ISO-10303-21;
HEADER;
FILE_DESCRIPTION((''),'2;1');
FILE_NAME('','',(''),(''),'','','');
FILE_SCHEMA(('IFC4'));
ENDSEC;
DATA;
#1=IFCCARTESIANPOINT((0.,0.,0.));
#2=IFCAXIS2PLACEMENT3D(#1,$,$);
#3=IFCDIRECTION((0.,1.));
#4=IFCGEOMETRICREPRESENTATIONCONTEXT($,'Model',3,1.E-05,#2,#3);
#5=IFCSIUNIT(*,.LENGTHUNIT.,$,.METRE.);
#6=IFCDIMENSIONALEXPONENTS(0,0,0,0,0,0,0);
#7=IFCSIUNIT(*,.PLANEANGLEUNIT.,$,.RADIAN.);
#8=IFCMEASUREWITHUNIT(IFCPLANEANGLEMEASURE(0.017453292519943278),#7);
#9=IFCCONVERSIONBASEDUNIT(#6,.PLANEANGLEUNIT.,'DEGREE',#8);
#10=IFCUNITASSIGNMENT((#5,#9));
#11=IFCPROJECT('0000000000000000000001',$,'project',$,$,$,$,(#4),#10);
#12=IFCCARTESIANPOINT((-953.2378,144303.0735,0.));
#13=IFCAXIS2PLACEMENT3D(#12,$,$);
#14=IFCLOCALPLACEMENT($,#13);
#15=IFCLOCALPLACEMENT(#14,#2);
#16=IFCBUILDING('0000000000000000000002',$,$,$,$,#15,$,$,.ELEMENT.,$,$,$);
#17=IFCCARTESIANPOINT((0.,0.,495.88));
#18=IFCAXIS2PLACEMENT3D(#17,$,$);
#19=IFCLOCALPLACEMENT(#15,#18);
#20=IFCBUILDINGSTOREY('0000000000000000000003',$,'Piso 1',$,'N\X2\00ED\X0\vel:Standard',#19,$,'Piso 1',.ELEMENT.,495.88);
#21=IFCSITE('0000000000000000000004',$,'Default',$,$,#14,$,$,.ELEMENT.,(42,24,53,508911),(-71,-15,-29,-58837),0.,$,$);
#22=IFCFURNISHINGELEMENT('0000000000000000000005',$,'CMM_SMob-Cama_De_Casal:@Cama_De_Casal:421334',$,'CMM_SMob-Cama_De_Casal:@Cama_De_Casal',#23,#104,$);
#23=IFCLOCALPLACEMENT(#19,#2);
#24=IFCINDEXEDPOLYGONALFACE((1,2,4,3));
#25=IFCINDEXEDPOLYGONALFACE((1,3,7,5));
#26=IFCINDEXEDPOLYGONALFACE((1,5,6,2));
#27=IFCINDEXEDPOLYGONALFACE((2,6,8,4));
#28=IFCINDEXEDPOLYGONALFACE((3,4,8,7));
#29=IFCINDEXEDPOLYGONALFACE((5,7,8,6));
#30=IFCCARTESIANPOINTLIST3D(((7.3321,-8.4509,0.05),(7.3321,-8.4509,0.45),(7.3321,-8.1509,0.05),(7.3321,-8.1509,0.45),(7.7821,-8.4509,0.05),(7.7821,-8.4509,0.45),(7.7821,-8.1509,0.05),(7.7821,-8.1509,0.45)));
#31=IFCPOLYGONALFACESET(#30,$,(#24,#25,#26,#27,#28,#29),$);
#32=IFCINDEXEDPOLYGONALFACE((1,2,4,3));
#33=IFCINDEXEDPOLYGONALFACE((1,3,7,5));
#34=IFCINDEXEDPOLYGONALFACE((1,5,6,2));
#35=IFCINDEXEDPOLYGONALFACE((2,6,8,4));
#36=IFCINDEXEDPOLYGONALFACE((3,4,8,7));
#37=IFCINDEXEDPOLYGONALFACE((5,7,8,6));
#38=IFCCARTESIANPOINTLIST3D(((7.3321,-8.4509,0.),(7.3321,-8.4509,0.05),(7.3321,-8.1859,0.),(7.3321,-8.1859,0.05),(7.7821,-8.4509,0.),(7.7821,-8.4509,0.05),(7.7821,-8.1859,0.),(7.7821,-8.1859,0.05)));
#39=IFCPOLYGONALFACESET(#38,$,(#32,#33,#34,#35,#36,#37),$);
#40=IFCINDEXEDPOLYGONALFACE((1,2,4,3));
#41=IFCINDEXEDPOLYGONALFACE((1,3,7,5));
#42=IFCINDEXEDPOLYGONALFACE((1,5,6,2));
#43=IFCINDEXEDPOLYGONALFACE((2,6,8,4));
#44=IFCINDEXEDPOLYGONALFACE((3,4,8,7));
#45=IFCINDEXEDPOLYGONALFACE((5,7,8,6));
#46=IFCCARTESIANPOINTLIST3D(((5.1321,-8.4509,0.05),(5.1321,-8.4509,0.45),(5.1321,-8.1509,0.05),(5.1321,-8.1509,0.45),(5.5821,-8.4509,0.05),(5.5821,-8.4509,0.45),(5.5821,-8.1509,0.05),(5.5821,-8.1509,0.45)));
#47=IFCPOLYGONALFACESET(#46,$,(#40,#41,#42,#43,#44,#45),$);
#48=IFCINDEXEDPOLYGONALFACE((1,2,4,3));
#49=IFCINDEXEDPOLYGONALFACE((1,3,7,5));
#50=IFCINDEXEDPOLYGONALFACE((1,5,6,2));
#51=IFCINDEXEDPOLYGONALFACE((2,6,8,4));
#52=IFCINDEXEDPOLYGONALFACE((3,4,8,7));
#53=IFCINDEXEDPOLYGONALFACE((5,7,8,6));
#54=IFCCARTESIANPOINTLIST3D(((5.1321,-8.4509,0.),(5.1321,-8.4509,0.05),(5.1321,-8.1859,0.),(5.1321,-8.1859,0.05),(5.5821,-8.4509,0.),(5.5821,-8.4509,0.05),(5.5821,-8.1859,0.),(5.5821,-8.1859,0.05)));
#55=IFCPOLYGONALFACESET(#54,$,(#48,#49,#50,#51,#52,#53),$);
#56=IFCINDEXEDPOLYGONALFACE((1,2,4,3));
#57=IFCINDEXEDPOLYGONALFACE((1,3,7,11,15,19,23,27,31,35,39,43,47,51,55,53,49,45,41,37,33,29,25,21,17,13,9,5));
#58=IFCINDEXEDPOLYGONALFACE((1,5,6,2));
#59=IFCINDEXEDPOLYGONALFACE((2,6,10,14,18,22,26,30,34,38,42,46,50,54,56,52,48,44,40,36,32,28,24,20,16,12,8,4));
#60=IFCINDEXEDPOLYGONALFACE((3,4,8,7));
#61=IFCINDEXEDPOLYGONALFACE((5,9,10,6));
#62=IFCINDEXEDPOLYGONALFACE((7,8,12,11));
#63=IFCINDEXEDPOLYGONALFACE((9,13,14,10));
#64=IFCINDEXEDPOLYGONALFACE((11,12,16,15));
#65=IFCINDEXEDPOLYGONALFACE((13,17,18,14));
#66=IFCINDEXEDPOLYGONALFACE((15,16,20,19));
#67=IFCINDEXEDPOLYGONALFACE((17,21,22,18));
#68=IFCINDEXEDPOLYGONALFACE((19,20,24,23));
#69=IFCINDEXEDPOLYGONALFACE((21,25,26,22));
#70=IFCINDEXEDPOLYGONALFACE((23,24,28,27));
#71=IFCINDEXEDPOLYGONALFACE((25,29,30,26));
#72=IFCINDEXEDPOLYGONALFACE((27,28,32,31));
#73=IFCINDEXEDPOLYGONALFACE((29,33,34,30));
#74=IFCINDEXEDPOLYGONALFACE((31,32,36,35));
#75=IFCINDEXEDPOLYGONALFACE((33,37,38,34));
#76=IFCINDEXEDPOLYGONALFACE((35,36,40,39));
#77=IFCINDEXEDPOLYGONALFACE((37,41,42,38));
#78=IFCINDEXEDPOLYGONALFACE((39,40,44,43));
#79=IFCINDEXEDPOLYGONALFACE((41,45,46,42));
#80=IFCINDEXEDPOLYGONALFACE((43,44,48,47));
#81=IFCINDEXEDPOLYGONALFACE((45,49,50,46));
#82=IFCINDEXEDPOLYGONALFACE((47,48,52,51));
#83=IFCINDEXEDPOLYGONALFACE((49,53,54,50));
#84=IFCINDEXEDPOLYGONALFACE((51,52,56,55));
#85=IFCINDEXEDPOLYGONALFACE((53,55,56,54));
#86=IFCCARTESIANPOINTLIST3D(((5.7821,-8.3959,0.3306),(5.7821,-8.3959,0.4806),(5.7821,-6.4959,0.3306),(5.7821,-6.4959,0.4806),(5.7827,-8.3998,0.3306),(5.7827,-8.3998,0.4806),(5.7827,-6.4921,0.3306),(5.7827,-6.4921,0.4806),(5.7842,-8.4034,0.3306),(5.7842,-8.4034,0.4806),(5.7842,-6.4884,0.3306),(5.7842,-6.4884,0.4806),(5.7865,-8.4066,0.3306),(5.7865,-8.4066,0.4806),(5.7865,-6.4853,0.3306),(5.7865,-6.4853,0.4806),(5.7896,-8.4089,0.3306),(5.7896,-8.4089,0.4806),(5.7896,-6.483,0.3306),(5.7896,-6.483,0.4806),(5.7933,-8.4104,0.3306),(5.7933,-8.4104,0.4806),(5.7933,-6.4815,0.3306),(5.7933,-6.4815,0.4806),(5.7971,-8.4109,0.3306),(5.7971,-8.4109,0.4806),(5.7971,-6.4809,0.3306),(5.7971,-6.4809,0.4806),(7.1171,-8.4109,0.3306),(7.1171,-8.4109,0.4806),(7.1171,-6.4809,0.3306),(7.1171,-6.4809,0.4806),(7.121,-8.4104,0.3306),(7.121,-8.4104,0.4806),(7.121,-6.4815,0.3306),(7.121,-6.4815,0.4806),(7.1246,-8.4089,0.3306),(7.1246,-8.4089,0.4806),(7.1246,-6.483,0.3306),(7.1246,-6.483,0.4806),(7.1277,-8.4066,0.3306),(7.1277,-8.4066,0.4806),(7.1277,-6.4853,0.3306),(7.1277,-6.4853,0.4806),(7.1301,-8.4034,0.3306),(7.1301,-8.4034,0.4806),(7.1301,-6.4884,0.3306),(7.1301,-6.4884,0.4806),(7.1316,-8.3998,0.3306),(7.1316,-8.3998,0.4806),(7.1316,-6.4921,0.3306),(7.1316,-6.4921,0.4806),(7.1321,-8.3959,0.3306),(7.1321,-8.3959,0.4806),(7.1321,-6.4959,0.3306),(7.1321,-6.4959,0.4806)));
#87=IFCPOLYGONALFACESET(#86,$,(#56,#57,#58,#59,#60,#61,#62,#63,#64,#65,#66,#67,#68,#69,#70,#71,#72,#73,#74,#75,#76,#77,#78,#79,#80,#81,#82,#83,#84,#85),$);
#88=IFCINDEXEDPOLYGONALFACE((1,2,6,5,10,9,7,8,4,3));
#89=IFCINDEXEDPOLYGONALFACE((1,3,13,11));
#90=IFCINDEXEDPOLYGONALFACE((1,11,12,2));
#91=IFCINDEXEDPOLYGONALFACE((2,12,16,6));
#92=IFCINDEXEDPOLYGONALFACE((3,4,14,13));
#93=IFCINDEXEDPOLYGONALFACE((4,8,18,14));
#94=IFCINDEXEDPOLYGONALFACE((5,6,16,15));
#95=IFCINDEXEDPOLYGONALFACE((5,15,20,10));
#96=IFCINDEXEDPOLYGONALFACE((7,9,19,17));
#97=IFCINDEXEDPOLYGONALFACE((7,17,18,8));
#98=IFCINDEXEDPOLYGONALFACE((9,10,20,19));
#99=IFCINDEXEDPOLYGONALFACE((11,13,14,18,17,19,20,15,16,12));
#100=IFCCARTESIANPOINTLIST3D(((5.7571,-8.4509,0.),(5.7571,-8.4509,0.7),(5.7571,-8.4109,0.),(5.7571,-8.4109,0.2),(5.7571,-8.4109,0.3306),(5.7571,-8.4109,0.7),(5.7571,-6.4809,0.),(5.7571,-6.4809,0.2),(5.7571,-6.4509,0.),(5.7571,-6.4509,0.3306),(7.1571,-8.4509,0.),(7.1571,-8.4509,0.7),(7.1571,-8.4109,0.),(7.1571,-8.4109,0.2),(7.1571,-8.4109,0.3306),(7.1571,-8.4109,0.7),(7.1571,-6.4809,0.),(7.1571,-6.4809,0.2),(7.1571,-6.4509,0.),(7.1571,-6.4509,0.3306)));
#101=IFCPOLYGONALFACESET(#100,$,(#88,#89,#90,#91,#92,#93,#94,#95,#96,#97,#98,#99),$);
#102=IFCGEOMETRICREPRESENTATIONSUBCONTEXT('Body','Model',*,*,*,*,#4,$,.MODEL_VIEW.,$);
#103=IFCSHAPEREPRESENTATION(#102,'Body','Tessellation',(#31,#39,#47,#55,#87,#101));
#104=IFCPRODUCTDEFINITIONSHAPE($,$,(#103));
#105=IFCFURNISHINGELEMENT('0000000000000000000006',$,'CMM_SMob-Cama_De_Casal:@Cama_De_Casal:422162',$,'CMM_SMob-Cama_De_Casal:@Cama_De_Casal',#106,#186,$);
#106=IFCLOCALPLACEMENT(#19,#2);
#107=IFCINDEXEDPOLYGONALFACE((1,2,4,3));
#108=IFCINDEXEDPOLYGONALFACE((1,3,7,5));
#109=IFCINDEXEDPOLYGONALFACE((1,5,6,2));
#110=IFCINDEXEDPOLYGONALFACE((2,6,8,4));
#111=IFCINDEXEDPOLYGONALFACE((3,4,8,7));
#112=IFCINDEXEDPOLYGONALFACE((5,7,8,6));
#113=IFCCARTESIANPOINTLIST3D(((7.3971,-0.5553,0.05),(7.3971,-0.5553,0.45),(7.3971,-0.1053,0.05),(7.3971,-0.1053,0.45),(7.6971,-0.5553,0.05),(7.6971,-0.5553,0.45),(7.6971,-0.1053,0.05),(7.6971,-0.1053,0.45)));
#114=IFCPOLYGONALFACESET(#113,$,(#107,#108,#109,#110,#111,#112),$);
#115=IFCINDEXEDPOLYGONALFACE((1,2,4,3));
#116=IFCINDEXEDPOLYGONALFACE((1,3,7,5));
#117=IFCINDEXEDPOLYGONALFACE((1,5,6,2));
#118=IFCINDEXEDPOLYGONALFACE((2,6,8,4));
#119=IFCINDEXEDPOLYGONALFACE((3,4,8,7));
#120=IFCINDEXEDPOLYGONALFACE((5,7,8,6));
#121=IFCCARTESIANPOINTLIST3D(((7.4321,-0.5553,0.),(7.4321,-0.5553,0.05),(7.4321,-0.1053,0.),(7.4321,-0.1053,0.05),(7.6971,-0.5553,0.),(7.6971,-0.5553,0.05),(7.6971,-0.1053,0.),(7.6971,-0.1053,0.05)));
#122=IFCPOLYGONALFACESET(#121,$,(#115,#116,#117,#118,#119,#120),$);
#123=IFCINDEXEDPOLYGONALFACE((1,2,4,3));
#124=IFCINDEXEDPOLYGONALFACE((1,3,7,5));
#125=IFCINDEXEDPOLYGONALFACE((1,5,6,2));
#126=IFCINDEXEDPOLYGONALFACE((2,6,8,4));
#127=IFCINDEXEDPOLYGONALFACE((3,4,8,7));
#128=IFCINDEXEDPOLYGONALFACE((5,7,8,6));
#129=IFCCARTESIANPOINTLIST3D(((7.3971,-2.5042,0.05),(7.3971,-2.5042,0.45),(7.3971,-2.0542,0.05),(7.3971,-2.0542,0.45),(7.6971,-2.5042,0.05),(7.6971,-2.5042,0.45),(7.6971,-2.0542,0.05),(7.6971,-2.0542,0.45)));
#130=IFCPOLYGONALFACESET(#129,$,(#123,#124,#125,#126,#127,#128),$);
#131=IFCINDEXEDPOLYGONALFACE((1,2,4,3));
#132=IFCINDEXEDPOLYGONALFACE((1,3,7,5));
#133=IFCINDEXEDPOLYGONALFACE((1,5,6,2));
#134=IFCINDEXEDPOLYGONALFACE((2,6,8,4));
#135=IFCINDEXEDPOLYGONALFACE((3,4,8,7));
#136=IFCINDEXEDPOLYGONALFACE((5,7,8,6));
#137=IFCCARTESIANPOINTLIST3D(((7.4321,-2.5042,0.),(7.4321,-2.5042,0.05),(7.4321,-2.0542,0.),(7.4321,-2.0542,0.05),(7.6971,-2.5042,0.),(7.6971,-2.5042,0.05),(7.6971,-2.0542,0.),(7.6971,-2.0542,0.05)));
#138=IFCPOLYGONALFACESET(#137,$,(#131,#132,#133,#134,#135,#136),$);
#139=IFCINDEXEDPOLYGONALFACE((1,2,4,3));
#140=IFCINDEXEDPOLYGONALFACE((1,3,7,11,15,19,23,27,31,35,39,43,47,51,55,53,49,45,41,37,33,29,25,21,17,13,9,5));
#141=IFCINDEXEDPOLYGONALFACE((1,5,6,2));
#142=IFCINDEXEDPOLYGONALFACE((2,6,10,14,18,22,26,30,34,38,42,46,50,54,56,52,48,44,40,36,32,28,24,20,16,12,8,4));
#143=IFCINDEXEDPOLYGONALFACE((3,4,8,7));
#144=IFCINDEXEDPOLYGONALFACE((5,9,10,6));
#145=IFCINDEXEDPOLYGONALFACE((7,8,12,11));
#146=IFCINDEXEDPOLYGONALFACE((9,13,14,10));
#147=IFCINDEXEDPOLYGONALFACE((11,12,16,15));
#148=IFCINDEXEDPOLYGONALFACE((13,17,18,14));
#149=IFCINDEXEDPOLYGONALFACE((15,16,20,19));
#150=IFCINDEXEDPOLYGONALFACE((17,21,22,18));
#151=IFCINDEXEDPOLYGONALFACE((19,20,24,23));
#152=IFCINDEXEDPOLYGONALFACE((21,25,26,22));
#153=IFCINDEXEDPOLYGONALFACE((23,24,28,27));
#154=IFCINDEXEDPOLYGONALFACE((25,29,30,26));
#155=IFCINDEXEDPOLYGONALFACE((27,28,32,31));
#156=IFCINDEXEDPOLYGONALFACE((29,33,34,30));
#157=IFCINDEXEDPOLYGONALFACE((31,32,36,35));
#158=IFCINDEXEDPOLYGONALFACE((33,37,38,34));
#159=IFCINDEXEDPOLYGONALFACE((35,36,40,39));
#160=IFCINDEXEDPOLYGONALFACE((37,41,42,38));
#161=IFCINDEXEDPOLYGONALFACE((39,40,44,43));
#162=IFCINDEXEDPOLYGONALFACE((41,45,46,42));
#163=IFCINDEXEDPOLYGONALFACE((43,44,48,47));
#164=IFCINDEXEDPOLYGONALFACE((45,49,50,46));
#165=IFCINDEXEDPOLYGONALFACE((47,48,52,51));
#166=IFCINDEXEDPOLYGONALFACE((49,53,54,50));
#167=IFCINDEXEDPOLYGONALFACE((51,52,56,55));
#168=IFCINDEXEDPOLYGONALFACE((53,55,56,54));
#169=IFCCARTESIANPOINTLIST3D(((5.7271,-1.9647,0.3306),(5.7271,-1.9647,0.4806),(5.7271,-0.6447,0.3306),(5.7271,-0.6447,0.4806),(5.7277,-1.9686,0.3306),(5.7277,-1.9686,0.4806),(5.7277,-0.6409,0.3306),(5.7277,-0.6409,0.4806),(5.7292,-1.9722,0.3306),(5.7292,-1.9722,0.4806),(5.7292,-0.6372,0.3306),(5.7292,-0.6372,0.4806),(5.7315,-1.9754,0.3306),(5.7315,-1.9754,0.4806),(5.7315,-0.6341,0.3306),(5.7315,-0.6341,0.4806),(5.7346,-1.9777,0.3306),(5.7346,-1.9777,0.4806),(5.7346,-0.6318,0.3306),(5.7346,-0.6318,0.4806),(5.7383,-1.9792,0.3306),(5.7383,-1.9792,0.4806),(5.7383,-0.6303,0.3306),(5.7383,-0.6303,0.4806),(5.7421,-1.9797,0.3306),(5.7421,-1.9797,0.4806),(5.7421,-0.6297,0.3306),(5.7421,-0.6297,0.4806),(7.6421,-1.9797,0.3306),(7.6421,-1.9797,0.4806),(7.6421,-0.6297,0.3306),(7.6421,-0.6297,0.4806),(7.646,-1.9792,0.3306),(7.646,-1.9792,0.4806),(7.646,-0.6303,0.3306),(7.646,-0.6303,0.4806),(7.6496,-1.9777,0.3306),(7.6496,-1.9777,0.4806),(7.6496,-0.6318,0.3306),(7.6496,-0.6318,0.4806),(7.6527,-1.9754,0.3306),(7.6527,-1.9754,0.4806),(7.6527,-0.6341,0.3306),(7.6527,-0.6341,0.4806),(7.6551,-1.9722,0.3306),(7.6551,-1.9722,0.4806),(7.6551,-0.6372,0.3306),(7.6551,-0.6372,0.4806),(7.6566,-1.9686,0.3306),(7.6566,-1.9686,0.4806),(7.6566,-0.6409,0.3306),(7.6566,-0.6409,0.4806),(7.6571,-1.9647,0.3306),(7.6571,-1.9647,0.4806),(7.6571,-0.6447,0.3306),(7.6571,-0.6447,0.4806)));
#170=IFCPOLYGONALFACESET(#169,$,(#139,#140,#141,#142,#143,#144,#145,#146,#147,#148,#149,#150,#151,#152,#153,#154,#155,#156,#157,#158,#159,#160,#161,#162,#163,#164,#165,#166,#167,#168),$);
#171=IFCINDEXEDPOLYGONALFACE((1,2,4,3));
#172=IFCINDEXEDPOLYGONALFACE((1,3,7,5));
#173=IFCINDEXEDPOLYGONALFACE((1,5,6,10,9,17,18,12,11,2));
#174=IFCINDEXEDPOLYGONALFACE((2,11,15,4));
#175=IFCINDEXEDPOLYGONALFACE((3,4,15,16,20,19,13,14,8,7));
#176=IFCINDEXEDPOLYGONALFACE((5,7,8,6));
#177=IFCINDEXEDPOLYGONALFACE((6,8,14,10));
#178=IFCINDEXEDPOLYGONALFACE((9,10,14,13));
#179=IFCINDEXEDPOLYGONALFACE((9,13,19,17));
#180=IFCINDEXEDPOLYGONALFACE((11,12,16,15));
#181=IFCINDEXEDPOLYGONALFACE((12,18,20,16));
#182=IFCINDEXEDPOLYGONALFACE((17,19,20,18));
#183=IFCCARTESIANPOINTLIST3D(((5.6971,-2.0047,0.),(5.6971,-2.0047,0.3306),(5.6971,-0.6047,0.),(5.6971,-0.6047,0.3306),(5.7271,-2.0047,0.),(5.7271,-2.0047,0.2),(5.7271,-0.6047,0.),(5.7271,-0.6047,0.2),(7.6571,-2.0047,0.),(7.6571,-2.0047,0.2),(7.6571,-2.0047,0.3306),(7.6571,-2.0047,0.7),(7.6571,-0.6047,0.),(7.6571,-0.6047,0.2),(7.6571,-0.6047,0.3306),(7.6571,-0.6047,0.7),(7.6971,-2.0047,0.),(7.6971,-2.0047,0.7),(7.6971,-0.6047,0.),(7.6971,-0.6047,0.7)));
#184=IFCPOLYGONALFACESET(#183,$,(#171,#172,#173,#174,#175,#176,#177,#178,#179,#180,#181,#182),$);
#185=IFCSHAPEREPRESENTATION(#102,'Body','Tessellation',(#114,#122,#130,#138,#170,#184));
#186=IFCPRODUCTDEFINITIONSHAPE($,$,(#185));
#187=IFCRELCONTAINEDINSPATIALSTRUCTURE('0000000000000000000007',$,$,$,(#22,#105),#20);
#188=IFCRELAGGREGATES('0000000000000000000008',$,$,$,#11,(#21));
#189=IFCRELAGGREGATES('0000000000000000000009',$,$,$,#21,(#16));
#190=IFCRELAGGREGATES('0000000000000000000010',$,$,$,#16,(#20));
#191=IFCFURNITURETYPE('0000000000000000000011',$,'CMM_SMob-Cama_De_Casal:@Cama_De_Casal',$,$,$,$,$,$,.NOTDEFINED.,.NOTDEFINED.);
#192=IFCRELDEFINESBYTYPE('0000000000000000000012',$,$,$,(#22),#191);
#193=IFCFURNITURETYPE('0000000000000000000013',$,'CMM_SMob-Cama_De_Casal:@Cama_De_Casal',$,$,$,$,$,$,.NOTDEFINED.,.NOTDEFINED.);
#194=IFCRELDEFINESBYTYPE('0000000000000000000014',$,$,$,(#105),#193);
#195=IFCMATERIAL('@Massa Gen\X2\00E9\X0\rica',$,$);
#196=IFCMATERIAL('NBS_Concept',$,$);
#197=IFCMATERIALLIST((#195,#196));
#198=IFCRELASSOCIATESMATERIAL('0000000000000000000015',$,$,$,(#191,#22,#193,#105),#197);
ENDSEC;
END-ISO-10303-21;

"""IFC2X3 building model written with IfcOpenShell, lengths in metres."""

from ifc_helpers import new_model, entity, si_unit, converted_unit, direction, frame, frame_2d, origin, origin_2d_with_axis, place, context, subcontext, project, spatial, polyline, circle_curve, parameter, trimmed, segment, composite_curve, rectangle, outline, extrude, source, transform, mapped, material, material_list, type_object, type_shapes, element, save


model = new_model("IFC2X3")

# Units and contexts
model_context = context("Model", 3, precision=1e-05, world=origin(), true_north=direction((0.0, 1.0)))
body_context = subcontext(model_context, "Body", "Model", "MODEL_VIEW")
ifc_project = project(units=[si_unit("LENGTHUNIT", "METRE"), converted_unit("PLANEANGLEUNIT", "DEGREE", entity("IfcPlaneAngleMeasure", 0.017453292519943278), si_unit("PLANEANGLEUNIT", "RADIAN"), dimensions=[0, 0, 0, 0, 0, 0, 0])], contexts=[model_context])

# Site, building, storey
site_placement = place(None, frame((-953.2378, 144303.0735, 0.0)))
site = spatial("IfcSite", under=ifc_project, at=site_placement, Name="Default", CompositionType="ELEMENT", RefLatitude=(42, 24, 53, 508911), RefLongitude=(-71, -15, -29, -58837), RefElevation=0.0)
building_placement = place(site_placement, origin())
building = spatial("IfcBuilding", under=site, at=building_placement, CompositionType="ELEMENT")
storey_placement = place(building_placement, frame((0.0, 0.0, 495.88)))
storey = spatial("IfcBuildingStorey", under=building, at=storey_placement, Name="Piso 1", ObjectType="Nível:Standard", LongName="Piso 1", CompositionType="ELEMENT", Elevation=495.88)

# Furnishing elements
ifc_material_1 = material(Name="@Massa Genérica")
ifc_material_2 = material(Name="NBS_Concept")
ifc_material_list = material_list([ifc_material_1, ifc_material_2])
furniture_type_1 = type_object("IfcFurnitureType", Name="CMM_SMob-Cama_De_Casal:@Cama_De_Casal", AssemblyPlace="NOTDEFINED", material=ifc_material_list)
shared_shape_1 = source(origin(), body_context, "Body", "SweptSolid", [
    extrude(rectangle(XDim=0.3, YDim=0.45, at=origin_2d_with_axis()), frame((-1.1, -0.15, 0.05), z_axis=(0.0, 0.0, 1.0), x_axis=(0.0, 1.0, 0.0)), (0.0, 0.0, 1.0), 0.4),
    extrude(rectangle(XDim=0.265, YDim=0.45, at=frame_2d((0.0, 0.0), x_axis=(1.0, 0.0))), frame((-1.1, -0.1325, 0.0), z_axis=(0.0, 0.0, 1.0), x_axis=(0.0, -1.0, 0.0)), (0.0, 0.0, 1.0), 0.05),
    extrude(rectangle(XDim=0.45, YDim=0.3, at=frame_2d((0.0, 0.0), x_axis=(1.0, 0.0))), frame((1.1, -0.15, 0.05)), (0.0, 0.0, 1.0), 0.4),
    extrude(rectangle(XDim=0.45, YDim=0.265, at=origin_2d_with_axis()), frame((1.1, -0.1325, 0.0), z_axis=(0.0, 0.0, 1.0), x_axis=(-1.0, 0.0, 0.0)), (0.0, 0.0, 1.0), 0.05),
    extrude(outline(composite_curve([segment(polyline([(-0.66, -0.965), (0.66, -0.965)]), True, "CONTINUOUS"), segment(trimmed(circle_curve(frame_2d((0.66, -0.95), x_axis=(-1.0, 0.0)), 0.015), [parameter(90.0)], [parameter(180.0)], True, "PARAMETER"), True, "CONTINUOUS"), segment(polyline([(0.675, -0.95), (0.675, 0.95)]), True, "CONTINUOUS"), segment(trimmed(circle_curve(frame_2d((0.66, 0.95), x_axis=(-1.0, 0.0)), 0.015), [parameter(180.0)], [parameter(270.0)], True, "PARAMETER"), True, "CONTINUOUS"), segment(polyline([(0.66, 0.965), (-0.66, 0.965)]), True, "CONTINUOUS"), segment(trimmed(circle_curve(frame_2d((-0.66, 0.95), x_axis=(-1.0, 0.0)), 0.015), [parameter(270.0)], [parameter(0.0)], True, "PARAMETER"), True, "CONTINUOUS"), segment(polyline([(-0.675, 0.95), (-0.675, -0.95)]), True, "CONTINUOUS"), segment(trimmed(circle_curve(frame_2d((-0.66, -0.95), x_axis=(-1.0, 0.0)), 0.015), [parameter(0.0)], [parameter(90.0)], True, "PARAMETER"), True, "CONTINUOUS")], self_intersect=False)), frame((0.0, -1.005, 0.3306), z_axis=(0.0, 0.0, 1.0), x_axis=(-1.0, 0.0, 0.0)), (0.0, 0.0, 1.0), 0.15),
    extrude(outline(polyline([(-0.2461, -1.16), (-0.2461, -1.19), (0.0845, -1.19), (0.0845, 0.77), (0.4539, 0.77), (0.4539, 0.81), (-0.2461, 0.81), (-0.2461, 0.77), (-0.0461, 0.77), (-0.0461, -1.16), (-0.2461, -1.16)])), frame((-0.7, -0.81, 0.2461), z_axis=(-1.0, 0.0, 0.0), x_axis=(0.0, 0.0, 1.0)), (0.0, 0.0, -1.0), 1.4),
])
type_shapes(furniture_type_1, [shared_shape_1])
furnishing_1_placement = place(storey_placement, frame((6.4571, -8.4509, 0.0), z_axis=(0.0, 0.0, 1.0), x_axis=(-1.0, 0.0, 0.0)))
element("IfcFurnishingElement", 1, at=furnishing_1_placement, inside=storey, type_object=furniture_type_1, material=ifc_material_list, Name="CMM_SMob-Cama_De_Casal:@Cama_De_Casal:421334", ObjectType="CMM_SMob-Cama_De_Casal:@Cama_De_Casal", context=body_context, shape_type="MappedRepresentation", body=[
    mapped(shared_shape_1, transform((0.0, 0.0, 0.0), scale=1.0)),
])
furniture_type_2 = type_object("IfcFurnitureType", Name="CMM_SMob-Cama_De_Casal:@Cama_De_Casal", AssemblyPlace="NOTDEFINED", material=ifc_material_list)
shared_shape_2 = source(origin(), body_context, "Body", "SweptSolid", [
    extrude(rectangle(XDim=0.3, YDim=0.45, at=frame_2d((0.0, 0.0), x_axis=(1.0, 0.0))), frame((-0.9745, -0.15, 0.05), z_axis=(0.0, 0.0, 1.0), x_axis=(0.0, 1.0, 0.0)), (0.0, 0.0, 1.0), 0.4),
    extrude(rectangle(XDim=0.265, YDim=0.45, at=frame_2d((0.0, 0.0), x_axis=(1.0, 0.0))), frame((-0.9745, -0.1325, 0.0), z_axis=(0.0, 0.0, 1.0), x_axis=(0.0, -1.0, 0.0)), (0.0, 0.0, 1.0), 0.05),
    extrude(rectangle(XDim=0.45, YDim=0.3, at=frame_2d((0.0, 0.0), x_axis=(1.0, 0.0))), frame((0.9745, -0.15, 0.05)), (0.0, 0.0, 1.0), 0.4),
    extrude(rectangle(XDim=0.45, YDim=0.265, at=origin_2d_with_axis()), frame((0.9745, -0.1325, 0.0), z_axis=(0.0, 0.0, 1.0), x_axis=(-1.0, 0.0, 0.0)), (0.0, 0.0, 1.0), 0.05),
    extrude(outline(composite_curve([segment(polyline([(-0.66, -0.965), (0.66, -0.965)]), True, "CONTINUOUS"), segment(trimmed(circle_curve(frame_2d((0.66, -0.95), x_axis=(-1.0, 0.0)), 0.015), [parameter(90.0)], [parameter(180.0)], True, "PARAMETER"), True, "CONTINUOUS"), segment(polyline([(0.675, -0.95), (0.675, 0.95)]), True, "CONTINUOUS"), segment(trimmed(circle_curve(frame_2d((0.66, 0.95), x_axis=(-1.0, 0.0)), 0.015), [parameter(180.0)], [parameter(270.0)], True, "PARAMETER"), True, "CONTINUOUS"), segment(polyline([(0.66, 0.965), (-0.66, 0.965)]), True, "CONTINUOUS"), segment(trimmed(circle_curve(frame_2d((-0.66, 0.95), x_axis=(-1.0, 0.0)), 0.015), [parameter(270.0)], [parameter(0.0)], True, "PARAMETER"), True, "CONTINUOUS"), segment(polyline([(-0.675, 0.95), (-0.675, -0.95)]), True, "CONTINUOUS"), segment(trimmed(circle_curve(frame_2d((-0.66, -0.95), x_axis=(-1.0, 0.0)), 0.015), [parameter(0.0)], [parameter(90.0)], True, "PARAMETER"), True, "CONTINUOUS")], self_intersect=False)), frame((0.0, -1.005, 0.3306), z_axis=(0.0, 0.0, 1.0), x_axis=(-1.0, 0.0, 0.0)), (0.0, 0.0, 1.0), 0.15),
    extrude(outline(polyline([(-0.2461, -1.16), (-0.2461, -1.19), (0.0845, -1.19), (0.0845, 0.77), (0.4539, 0.77), (0.4539, 0.81), (-0.2461, 0.81), (-0.2461, 0.77), (-0.0461, 0.77), (-0.0461, -1.16), (-0.2461, -1.16)])), frame((-0.7, -0.81, 0.2461), z_axis=(-1.0, 0.0, 0.0), x_axis=(0.0, 0.0, 1.0)), (0.0, 0.0, -1.0), 1.4),
])
type_shapes(furniture_type_2, [shared_shape_2])
furnishing_2_placement = place(storey_placement, frame((7.6971, -1.3047, 0.0), z_axis=(0.0, 0.0, 1.0), x_axis=(0.0, -1.0, 0.0)))
element("IfcFurnishingElement", 2, at=furnishing_2_placement, inside=storey, type_object=furniture_type_2, material=ifc_material_list, Name="CMM_SMob-Cama_De_Casal:@Cama_De_Casal:422162", ObjectType="CMM_SMob-Cama_De_Casal:@Cama_De_Casal", context=body_context, shape_type="MappedRepresentation", body=[
    mapped(shared_shape_2, transform((0.0, 0.0, 0.0), scale=1.0)),
])

save(model, "model.ifc")
